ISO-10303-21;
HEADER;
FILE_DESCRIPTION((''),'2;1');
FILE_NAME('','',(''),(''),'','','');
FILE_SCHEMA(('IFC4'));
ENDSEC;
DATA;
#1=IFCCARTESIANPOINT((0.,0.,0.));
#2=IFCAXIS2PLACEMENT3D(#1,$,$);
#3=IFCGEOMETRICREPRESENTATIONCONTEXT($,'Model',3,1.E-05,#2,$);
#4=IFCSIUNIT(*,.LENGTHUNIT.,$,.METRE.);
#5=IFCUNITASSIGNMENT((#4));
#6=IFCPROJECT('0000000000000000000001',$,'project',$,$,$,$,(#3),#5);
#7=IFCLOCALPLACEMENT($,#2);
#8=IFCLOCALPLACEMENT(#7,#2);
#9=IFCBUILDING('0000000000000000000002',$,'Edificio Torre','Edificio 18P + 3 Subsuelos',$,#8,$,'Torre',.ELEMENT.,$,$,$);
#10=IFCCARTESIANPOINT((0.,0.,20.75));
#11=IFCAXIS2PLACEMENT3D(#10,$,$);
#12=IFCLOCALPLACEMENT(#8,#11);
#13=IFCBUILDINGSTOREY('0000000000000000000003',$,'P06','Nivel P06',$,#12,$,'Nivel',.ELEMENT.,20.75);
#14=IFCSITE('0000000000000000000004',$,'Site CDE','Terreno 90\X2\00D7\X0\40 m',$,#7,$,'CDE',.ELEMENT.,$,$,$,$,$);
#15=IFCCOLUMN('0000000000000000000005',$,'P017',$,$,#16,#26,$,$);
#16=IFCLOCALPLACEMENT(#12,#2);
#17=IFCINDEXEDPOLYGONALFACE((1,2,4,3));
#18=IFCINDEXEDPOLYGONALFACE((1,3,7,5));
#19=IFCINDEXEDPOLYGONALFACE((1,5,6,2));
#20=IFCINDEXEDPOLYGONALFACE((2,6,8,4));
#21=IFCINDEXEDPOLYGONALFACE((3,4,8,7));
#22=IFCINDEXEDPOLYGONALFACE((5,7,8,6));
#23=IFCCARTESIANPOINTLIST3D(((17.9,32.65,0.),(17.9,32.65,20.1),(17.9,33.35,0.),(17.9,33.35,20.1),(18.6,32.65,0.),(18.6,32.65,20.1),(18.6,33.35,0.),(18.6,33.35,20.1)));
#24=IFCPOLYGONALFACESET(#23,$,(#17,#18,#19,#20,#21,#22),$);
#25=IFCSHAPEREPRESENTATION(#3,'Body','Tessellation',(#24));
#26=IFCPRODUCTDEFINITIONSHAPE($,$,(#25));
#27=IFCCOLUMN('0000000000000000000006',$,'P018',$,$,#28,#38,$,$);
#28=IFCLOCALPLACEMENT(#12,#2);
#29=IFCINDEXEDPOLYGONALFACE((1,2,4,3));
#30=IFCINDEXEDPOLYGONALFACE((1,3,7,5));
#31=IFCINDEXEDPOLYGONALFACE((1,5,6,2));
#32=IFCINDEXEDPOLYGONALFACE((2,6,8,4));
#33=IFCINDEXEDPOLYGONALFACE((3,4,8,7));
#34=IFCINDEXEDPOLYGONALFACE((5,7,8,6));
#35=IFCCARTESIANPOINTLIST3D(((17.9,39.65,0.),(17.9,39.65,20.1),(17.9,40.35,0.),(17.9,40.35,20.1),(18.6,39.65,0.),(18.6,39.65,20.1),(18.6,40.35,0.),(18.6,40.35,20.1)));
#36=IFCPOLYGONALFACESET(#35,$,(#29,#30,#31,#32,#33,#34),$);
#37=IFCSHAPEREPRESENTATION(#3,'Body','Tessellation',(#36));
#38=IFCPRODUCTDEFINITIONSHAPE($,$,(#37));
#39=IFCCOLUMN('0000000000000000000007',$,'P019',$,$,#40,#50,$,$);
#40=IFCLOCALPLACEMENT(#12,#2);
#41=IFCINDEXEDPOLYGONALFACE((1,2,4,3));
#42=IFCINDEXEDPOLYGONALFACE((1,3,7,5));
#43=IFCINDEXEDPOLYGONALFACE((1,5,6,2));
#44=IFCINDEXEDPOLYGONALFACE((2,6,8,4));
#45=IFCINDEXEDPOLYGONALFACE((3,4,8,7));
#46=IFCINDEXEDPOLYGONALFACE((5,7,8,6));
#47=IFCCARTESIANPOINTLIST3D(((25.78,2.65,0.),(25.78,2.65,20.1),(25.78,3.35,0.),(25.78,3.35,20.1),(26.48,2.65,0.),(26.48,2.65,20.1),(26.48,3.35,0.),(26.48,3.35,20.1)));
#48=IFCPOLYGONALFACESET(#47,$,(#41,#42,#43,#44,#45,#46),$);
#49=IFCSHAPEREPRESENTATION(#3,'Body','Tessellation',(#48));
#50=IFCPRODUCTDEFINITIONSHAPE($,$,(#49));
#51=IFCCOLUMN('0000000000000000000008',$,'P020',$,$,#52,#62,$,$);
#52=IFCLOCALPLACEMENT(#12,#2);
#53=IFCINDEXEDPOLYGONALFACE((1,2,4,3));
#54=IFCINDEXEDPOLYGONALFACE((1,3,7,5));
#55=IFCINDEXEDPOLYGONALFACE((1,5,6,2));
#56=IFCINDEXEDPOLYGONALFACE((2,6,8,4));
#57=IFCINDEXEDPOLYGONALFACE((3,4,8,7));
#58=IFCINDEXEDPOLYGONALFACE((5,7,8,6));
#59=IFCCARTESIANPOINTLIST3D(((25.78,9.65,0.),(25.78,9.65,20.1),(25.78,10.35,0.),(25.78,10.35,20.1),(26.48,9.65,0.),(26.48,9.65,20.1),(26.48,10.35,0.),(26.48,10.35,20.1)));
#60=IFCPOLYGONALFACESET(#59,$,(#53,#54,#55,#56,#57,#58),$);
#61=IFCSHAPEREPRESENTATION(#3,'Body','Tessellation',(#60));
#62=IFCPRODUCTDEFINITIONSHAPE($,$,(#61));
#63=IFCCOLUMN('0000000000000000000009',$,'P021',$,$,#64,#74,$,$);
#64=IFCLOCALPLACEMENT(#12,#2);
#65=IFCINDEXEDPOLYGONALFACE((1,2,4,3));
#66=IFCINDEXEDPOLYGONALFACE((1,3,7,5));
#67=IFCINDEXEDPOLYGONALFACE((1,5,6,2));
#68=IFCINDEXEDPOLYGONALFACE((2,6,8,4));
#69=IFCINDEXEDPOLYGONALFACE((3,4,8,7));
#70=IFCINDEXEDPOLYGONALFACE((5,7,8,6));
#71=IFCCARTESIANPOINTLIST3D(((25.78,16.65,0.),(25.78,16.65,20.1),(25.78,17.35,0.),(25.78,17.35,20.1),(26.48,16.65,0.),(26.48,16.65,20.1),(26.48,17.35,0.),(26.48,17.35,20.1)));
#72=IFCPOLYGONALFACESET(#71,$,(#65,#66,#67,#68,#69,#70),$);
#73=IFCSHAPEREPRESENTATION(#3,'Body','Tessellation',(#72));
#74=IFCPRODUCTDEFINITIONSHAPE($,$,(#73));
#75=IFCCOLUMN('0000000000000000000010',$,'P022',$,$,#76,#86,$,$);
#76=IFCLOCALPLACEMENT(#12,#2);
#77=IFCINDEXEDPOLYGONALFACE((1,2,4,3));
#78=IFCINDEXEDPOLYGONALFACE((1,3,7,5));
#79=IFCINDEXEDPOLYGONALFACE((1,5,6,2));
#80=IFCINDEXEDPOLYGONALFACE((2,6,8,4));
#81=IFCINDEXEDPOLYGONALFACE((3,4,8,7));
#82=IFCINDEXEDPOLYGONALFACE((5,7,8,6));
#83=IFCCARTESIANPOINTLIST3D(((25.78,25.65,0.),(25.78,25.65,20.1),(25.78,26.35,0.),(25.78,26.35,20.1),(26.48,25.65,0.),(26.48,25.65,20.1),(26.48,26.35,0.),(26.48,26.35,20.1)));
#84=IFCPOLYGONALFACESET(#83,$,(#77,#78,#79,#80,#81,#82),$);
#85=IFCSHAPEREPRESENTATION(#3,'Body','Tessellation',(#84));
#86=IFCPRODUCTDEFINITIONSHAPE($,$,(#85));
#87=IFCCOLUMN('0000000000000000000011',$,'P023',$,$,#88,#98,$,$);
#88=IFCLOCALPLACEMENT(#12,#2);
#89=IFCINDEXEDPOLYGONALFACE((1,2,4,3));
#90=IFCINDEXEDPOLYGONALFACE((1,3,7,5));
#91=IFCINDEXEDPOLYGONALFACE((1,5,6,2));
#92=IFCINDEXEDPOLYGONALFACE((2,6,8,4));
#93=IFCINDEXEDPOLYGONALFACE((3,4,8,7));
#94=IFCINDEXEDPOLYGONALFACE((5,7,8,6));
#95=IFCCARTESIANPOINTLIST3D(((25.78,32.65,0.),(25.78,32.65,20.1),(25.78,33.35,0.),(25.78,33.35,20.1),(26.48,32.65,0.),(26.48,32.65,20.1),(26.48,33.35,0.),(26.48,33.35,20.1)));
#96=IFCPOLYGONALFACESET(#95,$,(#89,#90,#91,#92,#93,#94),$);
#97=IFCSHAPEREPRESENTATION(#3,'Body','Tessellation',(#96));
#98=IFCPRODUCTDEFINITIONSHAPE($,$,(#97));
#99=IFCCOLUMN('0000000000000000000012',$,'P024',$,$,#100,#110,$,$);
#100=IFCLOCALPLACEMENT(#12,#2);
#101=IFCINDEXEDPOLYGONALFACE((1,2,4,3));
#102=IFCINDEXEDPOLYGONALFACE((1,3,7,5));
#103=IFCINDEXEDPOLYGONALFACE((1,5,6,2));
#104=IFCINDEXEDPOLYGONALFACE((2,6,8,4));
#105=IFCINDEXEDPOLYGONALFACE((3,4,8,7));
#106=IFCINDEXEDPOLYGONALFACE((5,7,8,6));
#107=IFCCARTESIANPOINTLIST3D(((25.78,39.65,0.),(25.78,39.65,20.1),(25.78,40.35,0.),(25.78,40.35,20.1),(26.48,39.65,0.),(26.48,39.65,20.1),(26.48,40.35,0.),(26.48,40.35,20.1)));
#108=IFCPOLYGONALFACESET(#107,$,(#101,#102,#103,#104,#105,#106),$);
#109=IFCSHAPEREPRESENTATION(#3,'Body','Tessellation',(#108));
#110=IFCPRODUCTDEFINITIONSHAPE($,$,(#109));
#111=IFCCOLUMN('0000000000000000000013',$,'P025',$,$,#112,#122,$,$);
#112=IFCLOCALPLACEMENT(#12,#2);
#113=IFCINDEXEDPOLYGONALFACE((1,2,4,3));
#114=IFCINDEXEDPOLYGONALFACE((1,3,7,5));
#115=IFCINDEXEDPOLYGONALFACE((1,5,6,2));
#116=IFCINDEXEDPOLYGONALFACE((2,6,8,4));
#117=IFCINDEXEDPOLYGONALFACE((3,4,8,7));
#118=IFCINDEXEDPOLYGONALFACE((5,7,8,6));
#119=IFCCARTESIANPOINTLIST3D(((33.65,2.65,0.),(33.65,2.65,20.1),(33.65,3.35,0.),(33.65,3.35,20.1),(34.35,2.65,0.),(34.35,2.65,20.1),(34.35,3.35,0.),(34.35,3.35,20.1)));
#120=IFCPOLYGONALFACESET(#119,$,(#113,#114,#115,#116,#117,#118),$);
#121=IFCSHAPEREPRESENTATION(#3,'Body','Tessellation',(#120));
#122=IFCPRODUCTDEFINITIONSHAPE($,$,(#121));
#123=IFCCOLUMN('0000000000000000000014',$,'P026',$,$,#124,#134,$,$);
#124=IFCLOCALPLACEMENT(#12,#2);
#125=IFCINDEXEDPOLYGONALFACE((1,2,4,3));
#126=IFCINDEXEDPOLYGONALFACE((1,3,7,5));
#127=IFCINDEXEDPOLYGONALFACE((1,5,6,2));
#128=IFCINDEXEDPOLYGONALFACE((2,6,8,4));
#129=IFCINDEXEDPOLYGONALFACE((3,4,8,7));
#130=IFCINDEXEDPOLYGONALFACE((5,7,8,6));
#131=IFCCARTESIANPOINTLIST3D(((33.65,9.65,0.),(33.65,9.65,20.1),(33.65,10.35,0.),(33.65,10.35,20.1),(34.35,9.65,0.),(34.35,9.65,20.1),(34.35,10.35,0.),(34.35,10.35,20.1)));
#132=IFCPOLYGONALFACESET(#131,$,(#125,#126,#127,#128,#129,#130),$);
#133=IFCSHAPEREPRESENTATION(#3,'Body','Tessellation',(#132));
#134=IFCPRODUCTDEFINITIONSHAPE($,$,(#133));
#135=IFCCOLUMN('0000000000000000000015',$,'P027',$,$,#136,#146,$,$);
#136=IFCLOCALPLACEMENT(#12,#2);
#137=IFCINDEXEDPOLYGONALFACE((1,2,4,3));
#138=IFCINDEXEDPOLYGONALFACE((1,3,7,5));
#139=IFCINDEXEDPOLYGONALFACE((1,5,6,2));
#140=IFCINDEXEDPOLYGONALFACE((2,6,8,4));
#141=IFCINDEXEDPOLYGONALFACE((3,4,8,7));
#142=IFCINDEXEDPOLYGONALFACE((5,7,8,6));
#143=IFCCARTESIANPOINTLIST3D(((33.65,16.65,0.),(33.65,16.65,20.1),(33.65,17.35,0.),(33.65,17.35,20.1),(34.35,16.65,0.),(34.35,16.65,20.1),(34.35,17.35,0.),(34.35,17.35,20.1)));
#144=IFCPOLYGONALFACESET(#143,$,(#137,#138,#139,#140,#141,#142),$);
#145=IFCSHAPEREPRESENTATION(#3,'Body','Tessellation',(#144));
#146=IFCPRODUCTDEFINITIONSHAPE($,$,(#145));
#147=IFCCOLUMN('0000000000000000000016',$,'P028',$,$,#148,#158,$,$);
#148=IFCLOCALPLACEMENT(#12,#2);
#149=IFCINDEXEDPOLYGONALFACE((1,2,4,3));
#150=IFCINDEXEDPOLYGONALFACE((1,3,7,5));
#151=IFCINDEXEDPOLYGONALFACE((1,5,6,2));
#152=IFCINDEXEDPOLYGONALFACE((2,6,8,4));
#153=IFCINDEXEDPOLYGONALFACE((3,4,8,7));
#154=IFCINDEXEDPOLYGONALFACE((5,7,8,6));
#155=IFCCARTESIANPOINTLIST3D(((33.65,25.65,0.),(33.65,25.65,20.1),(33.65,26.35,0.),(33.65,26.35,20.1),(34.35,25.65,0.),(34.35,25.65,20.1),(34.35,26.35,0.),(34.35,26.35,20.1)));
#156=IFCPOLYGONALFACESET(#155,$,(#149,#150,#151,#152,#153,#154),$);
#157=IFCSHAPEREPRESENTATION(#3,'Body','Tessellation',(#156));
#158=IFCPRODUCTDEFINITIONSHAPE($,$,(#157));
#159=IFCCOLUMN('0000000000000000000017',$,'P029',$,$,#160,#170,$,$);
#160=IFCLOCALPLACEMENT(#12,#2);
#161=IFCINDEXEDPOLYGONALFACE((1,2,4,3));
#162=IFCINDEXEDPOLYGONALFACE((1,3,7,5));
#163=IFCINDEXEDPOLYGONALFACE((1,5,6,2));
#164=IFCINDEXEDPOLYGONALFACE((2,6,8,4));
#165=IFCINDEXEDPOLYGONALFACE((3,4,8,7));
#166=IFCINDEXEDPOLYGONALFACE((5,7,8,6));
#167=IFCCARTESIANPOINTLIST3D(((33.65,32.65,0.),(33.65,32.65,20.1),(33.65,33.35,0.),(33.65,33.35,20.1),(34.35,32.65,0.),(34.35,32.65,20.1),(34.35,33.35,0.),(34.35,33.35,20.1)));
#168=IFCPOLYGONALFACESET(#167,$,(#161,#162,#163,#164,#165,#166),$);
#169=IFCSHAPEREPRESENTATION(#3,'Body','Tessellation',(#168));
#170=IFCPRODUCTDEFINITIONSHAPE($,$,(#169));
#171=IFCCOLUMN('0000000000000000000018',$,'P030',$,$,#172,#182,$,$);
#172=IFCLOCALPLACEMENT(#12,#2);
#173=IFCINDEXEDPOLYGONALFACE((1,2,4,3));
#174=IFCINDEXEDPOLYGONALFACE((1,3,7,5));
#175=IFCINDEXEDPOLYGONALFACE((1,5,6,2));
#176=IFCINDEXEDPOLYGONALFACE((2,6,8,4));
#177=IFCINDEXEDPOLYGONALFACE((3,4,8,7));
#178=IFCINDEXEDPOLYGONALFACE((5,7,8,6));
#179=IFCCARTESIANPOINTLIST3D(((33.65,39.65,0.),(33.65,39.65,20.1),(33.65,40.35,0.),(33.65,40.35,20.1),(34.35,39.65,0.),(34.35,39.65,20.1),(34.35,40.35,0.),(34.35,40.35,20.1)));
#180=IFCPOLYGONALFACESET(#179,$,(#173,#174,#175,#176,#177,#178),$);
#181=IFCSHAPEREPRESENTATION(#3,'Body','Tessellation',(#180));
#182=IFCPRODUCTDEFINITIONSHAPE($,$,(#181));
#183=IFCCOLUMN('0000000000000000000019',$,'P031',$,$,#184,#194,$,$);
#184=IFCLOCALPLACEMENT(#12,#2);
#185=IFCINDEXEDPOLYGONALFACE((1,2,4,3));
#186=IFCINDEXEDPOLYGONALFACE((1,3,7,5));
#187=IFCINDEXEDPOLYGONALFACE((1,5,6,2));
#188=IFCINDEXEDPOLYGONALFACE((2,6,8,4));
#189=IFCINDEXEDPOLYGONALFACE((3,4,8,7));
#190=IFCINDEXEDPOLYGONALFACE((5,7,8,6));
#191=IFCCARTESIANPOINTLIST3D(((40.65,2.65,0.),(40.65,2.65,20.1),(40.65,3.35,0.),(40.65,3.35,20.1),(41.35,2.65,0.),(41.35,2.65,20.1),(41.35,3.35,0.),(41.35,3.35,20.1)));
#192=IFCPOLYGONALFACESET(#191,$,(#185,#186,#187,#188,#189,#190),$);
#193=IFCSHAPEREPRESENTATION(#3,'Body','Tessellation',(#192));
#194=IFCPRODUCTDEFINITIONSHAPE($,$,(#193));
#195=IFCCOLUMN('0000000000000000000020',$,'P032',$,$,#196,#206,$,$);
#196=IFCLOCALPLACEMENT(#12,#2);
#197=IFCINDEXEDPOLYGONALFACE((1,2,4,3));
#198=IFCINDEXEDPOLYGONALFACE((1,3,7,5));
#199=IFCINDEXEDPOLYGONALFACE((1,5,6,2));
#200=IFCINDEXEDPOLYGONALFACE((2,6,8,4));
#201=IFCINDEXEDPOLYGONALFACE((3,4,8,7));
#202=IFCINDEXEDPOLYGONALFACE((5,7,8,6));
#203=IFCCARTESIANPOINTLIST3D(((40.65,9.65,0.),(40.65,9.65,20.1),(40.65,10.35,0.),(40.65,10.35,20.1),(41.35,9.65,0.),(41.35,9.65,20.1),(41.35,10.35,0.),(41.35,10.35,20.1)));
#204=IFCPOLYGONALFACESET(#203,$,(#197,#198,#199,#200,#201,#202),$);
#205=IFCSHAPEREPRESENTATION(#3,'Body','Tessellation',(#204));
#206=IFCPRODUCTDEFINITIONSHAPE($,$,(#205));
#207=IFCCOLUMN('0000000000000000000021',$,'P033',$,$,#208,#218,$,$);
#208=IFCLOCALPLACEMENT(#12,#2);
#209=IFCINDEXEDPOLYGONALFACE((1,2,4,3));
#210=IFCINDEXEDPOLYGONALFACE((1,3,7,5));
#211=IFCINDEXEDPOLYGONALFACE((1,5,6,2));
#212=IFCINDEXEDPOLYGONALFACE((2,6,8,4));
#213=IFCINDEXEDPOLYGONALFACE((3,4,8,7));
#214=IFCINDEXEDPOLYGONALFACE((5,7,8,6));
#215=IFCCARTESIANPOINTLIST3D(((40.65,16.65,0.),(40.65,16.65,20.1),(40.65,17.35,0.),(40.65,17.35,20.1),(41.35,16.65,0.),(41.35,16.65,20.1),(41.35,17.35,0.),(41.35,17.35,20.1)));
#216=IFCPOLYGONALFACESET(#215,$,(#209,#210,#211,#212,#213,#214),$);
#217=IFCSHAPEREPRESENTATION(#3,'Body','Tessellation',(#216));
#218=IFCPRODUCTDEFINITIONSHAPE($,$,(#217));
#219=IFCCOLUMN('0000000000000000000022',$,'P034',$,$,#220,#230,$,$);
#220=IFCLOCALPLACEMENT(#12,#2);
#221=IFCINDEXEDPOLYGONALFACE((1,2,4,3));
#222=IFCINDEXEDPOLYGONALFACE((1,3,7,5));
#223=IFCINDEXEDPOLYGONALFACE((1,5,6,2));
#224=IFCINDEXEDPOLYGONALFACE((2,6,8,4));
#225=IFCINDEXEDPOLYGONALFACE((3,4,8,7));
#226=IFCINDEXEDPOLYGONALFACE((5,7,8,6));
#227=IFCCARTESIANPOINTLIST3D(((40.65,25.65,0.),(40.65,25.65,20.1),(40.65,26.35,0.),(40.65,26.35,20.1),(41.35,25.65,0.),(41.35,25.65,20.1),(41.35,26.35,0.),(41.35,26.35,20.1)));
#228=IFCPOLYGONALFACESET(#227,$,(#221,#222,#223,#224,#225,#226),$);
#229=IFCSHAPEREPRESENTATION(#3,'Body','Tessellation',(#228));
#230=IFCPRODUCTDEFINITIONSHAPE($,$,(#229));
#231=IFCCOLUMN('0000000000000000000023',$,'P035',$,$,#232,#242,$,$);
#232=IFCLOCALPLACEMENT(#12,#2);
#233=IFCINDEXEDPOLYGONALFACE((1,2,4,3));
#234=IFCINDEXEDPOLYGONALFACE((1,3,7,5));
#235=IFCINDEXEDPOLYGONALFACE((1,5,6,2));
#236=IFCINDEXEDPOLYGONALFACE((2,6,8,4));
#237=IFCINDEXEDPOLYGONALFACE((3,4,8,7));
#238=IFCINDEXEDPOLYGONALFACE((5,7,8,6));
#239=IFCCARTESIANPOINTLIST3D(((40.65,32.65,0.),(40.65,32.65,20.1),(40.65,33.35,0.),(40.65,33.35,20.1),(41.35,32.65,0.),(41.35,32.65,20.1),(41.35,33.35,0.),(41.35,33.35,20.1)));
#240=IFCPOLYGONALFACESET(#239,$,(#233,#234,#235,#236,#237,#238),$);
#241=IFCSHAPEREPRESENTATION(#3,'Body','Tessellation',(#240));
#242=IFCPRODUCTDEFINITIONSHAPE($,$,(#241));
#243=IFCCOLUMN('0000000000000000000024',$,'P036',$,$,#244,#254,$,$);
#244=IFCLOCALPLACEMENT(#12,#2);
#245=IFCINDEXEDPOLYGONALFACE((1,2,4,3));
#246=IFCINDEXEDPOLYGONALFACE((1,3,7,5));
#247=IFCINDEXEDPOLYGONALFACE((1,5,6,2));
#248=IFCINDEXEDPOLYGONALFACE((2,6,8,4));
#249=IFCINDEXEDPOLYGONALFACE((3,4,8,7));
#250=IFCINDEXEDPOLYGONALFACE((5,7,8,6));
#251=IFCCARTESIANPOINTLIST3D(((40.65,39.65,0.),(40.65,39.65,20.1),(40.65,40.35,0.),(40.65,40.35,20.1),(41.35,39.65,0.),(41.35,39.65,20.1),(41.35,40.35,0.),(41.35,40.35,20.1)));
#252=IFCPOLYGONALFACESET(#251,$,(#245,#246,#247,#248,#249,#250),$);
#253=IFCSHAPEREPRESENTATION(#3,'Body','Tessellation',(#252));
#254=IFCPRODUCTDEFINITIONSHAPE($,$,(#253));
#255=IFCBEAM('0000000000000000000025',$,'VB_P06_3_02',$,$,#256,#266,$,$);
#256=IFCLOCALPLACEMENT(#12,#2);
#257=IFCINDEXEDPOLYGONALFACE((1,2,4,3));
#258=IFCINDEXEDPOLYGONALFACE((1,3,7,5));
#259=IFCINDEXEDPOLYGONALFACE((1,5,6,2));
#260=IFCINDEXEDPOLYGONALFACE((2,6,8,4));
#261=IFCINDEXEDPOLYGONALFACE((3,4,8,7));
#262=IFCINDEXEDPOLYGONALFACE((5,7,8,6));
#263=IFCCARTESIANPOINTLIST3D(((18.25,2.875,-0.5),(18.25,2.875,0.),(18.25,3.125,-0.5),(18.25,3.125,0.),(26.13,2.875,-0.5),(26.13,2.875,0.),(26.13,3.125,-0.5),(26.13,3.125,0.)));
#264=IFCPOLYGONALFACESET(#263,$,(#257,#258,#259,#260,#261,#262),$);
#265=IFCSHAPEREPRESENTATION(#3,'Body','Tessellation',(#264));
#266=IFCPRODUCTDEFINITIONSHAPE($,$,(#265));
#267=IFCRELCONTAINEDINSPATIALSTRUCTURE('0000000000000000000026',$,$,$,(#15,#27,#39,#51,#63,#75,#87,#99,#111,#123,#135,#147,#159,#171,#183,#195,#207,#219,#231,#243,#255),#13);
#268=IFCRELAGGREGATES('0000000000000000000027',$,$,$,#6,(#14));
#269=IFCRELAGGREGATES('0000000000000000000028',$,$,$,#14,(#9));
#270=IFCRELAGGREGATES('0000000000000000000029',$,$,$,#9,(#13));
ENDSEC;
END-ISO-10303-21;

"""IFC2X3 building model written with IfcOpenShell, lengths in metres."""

from ifc_helpers import new_model, si_unit, frame, origin, origin_2d, place, context, project, spatial, rectangle, extrude, element, save


model = new_model("IFC2X3")

# Units and contexts
model_context = context("Model", 3, precision=1e-05, world=origin())
ifc_project = project(units=[si_unit("LENGTHUNIT", "METRE")], contexts=[model_context])

# Site, building, storey
site_placement = place(None, origin())
site = spatial("IfcSite", under=ifc_project, at=site_placement, Name="Site CDE", Description="Terreno 90×40 m", LongName="CDE", CompositionType="ELEMENT")
building_placement = place(site_placement, origin())
building = spatial("IfcBuilding", under=site, at=building_placement, Name="Edificio Torre", Description="Edificio 18P + 3 Subsuelos", LongName="Torre", CompositionType="ELEMENT")
storey_placement = place(building_placement, frame((0.0, 0.0, 20.75)))
storey = spatial("IfcBuildingStorey", under=building, at=storey_placement, Name="P06", Description="Nivel P06", LongName="Nivel", CompositionType="ELEMENT", Elevation=20.75)

# Columns
for number, where, name in (
    (1, (18.25, 33.0, 0.0), "P017"),
    (2, (18.25, 40.0, 0.0), "P018"),
    (3, (26.13, 3.0, 0.0), "P019"),
    (4, (26.13, 10.0, 0.0), "P020"),
    (5, (26.13, 17.0, 0.0), "P021"),
    (6, (26.13, 26.0, 0.0), "P022"),
    (7, (26.13, 33.0, 0.0), "P023"),
    (8, (26.13, 40.0, 0.0), "P024"),
    (9, (34.0, 3.0, 0.0), "P025"),
    (10, (34.0, 10.0, 0.0), "P026"),
    (11, (34.0, 17.0, 0.0), "P027"),
    (12, (34.0, 26.0, 0.0), "P028"),
    (13, (34.0, 33.0, 0.0), "P029"),
    (14, (34.0, 40.0, 0.0), "P030"),
    (15, (41.0, 3.0, 0.0), "P031"),
    (16, (41.0, 10.0, 0.0), "P032"),
    (17, (41.0, 17.0, 0.0), "P033"),
    (18, (41.0, 26.0, 0.0), "P034"),
    (19, (41.0, 33.0, 0.0), "P035"),
    (20, (41.0, 40.0, 0.0), "P036"),
):
    element("IfcColumn", number, at=place(storey_placement, frame(where)), inside=storey, Name=name, context=model_context, shape_type="SweptSolid", body=[
        extrude(rectangle(XDim=0.7, YDim=0.7, at=origin_2d()), origin(), (0.0, 0.0, 1.0), 20.1),
    ])

# Beam
beam_1_placement = place(storey_placement, frame((22.19, 3.0, -0.5)))
element("IfcBeam", 21, at=beam_1_placement, inside=storey, Name="VB_P06_3_02", context=model_context, shape_type="SweptSolid", body=[
    extrude(rectangle(XDim=7.88, YDim=0.25, at=origin_2d()), origin(), (0.0, 0.0, 1.0), 0.5),
])

save(model, "model.ifc")
